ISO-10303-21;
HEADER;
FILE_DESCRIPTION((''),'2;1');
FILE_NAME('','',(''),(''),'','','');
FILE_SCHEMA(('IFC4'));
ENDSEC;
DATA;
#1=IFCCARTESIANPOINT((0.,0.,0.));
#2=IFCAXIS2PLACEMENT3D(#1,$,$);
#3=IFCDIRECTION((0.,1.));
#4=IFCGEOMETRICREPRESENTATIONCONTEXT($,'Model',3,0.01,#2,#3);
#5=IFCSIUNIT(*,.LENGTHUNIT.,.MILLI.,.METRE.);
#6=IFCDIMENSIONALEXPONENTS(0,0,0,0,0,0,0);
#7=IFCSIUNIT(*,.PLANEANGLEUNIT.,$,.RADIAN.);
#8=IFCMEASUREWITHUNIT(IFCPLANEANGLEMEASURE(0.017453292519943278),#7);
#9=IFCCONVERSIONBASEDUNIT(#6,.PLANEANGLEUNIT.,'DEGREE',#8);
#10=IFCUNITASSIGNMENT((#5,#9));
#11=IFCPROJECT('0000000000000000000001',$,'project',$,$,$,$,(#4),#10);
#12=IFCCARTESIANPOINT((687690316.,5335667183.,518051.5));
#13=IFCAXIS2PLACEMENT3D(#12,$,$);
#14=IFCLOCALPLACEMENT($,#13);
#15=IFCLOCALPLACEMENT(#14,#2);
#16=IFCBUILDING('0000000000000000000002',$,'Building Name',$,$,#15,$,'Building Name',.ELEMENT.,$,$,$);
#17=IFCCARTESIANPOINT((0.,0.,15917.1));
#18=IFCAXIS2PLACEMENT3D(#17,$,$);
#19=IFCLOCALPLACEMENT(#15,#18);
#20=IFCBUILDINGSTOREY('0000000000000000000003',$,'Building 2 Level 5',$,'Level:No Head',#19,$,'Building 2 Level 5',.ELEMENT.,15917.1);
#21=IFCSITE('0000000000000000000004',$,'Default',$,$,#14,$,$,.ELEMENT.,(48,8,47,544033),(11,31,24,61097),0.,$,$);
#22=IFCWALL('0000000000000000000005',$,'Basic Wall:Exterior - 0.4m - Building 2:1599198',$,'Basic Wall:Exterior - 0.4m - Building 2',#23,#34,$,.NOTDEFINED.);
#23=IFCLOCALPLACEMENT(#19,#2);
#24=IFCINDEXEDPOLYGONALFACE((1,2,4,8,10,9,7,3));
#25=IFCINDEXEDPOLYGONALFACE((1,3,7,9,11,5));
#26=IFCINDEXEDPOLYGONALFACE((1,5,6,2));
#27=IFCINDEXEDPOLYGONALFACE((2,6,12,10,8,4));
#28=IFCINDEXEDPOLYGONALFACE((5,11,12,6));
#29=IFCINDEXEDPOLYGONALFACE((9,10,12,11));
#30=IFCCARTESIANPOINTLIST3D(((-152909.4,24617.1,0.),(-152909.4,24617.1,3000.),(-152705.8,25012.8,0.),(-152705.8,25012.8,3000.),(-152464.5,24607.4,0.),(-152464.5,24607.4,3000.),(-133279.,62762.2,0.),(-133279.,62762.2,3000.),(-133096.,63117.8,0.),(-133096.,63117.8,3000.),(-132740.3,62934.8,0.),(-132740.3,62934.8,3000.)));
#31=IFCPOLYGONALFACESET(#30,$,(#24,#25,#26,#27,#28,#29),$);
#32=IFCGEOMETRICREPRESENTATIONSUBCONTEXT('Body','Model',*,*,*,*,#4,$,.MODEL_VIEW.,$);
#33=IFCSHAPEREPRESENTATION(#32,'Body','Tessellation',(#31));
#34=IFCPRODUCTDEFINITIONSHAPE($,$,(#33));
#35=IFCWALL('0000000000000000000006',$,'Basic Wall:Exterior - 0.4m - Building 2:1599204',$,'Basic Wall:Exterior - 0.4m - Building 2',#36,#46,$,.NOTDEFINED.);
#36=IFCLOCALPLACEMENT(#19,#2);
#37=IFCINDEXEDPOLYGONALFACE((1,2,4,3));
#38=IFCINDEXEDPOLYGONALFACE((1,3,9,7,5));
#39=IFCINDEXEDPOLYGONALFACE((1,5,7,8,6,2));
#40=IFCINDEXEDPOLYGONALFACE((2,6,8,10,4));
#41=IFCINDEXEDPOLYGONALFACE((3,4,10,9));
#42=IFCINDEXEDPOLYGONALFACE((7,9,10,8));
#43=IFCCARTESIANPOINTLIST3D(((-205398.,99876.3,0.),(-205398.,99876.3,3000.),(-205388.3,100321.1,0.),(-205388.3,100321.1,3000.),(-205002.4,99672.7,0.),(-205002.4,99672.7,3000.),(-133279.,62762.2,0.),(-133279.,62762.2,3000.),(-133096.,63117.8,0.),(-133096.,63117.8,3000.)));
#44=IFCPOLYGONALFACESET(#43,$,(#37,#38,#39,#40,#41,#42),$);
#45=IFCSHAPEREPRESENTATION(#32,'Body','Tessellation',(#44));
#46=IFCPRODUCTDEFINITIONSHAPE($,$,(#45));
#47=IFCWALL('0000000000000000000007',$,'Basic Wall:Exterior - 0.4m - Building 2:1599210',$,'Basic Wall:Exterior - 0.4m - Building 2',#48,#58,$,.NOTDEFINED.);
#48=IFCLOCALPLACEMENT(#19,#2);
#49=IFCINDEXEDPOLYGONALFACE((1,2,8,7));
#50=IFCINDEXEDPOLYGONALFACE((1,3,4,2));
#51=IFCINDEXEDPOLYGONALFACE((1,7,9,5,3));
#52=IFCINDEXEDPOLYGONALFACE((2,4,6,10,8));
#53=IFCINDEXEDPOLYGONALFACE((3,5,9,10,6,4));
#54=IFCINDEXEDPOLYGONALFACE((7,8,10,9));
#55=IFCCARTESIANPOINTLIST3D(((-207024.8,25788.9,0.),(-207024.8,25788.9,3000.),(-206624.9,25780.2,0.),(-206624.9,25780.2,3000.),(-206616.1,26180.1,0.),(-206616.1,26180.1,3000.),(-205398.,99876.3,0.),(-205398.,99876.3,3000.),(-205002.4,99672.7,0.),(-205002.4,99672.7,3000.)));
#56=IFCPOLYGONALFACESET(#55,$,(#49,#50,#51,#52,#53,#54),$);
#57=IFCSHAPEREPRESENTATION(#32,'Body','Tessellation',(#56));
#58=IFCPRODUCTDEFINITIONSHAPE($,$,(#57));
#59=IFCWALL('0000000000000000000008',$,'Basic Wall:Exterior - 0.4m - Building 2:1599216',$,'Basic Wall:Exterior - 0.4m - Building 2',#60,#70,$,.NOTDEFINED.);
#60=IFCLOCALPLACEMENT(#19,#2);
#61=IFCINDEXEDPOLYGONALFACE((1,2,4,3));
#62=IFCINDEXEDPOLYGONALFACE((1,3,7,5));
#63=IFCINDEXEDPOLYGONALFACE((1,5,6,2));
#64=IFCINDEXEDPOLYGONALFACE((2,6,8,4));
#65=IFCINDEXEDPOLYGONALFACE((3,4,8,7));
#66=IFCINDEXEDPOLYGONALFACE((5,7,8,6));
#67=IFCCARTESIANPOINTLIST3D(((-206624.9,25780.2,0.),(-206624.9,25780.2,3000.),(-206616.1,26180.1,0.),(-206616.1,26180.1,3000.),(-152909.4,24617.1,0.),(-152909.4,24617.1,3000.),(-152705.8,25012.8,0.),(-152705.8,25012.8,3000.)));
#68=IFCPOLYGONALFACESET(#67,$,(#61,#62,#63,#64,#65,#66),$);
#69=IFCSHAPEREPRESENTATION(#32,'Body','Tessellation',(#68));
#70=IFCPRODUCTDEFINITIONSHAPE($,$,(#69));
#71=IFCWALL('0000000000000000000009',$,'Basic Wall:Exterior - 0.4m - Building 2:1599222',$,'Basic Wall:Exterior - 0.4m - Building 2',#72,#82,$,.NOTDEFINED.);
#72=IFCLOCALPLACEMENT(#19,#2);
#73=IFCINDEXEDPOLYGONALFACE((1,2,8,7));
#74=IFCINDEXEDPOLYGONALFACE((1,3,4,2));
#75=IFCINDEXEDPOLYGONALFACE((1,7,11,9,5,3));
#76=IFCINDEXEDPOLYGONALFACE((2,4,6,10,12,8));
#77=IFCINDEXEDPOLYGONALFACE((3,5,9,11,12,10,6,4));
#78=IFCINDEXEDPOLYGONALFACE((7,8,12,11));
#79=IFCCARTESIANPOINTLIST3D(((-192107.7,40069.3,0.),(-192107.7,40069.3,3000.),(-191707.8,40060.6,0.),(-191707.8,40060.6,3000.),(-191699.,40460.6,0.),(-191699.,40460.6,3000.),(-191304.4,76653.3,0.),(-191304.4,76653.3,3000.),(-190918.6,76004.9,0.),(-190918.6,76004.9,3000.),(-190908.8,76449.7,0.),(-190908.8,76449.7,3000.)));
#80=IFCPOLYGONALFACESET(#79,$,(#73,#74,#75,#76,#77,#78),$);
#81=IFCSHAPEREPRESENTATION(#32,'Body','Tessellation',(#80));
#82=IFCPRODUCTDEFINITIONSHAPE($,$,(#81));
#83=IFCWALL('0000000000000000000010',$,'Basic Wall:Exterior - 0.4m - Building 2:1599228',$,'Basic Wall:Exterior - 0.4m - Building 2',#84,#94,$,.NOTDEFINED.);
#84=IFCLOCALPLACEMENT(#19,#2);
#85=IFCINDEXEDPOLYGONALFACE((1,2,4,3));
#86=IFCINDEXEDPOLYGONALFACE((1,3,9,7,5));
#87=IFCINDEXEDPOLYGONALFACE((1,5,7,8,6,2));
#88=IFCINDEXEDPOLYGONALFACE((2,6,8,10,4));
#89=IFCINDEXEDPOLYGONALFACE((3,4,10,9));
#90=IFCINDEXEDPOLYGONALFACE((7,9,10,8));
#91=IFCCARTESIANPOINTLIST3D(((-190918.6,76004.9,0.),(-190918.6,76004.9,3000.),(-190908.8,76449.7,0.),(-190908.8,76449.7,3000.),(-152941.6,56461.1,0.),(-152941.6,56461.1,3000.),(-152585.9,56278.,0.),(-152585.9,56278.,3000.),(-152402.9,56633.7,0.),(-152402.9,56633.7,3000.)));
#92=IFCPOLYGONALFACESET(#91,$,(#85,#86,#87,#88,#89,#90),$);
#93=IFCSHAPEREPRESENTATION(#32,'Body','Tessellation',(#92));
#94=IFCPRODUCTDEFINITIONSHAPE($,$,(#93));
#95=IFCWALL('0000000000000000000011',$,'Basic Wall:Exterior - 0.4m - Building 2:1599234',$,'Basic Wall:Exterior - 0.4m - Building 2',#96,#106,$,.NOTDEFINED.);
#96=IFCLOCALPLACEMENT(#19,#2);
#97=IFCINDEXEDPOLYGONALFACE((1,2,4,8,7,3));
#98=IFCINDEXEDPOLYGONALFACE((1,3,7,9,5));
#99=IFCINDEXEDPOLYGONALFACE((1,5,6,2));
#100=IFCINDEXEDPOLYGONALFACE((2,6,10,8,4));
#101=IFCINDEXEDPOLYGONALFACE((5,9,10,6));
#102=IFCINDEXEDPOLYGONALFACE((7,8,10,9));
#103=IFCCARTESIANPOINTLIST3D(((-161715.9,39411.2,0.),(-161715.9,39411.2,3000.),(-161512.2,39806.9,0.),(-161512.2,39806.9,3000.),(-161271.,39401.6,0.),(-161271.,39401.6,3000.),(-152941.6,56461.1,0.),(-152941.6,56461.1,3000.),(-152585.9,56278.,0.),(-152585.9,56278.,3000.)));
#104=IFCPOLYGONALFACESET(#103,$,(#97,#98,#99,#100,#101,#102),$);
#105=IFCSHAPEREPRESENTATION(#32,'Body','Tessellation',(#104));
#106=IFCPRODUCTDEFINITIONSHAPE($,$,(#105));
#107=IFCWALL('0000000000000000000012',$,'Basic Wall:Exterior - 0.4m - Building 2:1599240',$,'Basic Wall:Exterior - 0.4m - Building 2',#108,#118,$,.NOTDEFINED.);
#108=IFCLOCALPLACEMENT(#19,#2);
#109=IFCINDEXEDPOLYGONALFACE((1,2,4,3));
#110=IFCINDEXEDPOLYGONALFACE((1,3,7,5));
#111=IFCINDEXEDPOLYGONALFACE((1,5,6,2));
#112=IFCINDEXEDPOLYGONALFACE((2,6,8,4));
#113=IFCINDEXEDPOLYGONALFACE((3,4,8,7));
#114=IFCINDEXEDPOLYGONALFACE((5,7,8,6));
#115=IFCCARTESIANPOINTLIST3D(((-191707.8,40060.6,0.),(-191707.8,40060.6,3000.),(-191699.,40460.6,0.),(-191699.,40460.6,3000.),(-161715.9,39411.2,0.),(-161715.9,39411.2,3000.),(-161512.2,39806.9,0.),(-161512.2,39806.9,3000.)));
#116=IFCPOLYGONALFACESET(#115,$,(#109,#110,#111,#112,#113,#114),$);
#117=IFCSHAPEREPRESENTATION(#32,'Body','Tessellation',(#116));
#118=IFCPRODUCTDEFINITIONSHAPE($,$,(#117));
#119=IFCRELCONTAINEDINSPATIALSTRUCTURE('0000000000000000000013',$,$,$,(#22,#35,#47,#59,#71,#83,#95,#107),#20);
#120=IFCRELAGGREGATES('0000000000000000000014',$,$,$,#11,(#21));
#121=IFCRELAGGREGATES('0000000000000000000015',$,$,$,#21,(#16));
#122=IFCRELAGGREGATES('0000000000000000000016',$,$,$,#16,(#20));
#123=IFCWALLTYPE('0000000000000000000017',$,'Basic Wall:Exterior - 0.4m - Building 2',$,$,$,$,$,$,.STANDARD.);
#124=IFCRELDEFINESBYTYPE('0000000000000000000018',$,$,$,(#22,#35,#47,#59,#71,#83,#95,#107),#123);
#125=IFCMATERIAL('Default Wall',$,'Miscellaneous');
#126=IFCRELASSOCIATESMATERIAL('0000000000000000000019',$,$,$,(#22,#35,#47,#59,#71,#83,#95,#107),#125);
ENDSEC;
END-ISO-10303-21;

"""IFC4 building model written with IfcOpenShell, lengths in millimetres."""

from ifc_helpers import new_model, entity, si_unit, converted_unit, direction, frame, origin, place, context, subcontext, project, spatial, indexed_curve, outline, extrude, material, type_object, element, save


model = new_model("IFC4")

# Units and contexts
model_context = context("Model", 3, precision=0.01, world=origin(), true_north=direction((0.0, 1.0)))
body_context = subcontext(model_context, "Body", "Model", "MODEL_VIEW")
ifc_project = project(units=[si_unit("LENGTHUNIT", "METRE", prefix="MILLI"), converted_unit("PLANEANGLEUNIT", "DEGREE", entity("IfcPlaneAngleMeasure", 0.017453292519943278), si_unit("PLANEANGLEUNIT", "RADIAN"), dimensions=[0, 0, 0, 0, 0, 0, 0])], contexts=[model_context])

# Site, building, storey
site_placement = place(None, frame((687690316.0, 5335667183.0, 518051.5)))
site = spatial("IfcSite", under=ifc_project, at=site_placement, Name="Default", CompositionType="ELEMENT", RefLatitude=(48, 8, 47, 544033), RefLongitude=(11, 31, 24, 61097), RefElevation=0.0)
building_placement = place(site_placement, origin())
building = spatial("IfcBuilding", under=site, at=building_placement, Name="Building Name", LongName="Building Name", CompositionType="ELEMENT")
storey_placement = place(building_placement, frame((0.0, 0.0, 15917.1)))
storey = spatial("IfcBuildingStorey", under=building, at=storey_placement, Name="Building 2 Level 5", ObjectType="Level:No Head", LongName="Building 2 Level 5", CompositionType="ELEMENT", Elevation=15917.1)

# Walls
ifc_material_1 = material(Name="Default Wall", Category="Miscellaneous")
wall_type = type_object("IfcWallType", Name="Basic Wall:Exterior - 0.4m - Building 2", PredefinedType="STANDARD")
wall_1_placement = place(storey_placement, frame((-152731.6, 24525.6, 0.0), z_axis=(0.0, 0.0, 1.0), x_axis=(0.457585, 0.889166, 0.0)))
element("IfcWall", 1, at=wall_1_placement, inside=storey, type_object=wall_type, material=ifc_material_1, Name="Basic Wall:Exterior - 0.4m - Building 2:1599198", ObjectType="Basic Wall:Exterior - 0.4m - Building 2", PredefinedType="NOTDEFINED", context=body_context, shape_type="SweptSolid", body=[
    extrude(outline(indexed_curve([(43299.8, -200.0), (43299.8, 200.0), (42899.8, 200.0), (445.0, 200.0), (0.0, 200.0), (195.0, -200.0), (43299.8, -200.0)], self_intersect=False)), origin(), (0.0, 0.0, 1.0), 3000.0),
])
wall_2_placement = place(storey_placement, frame((-133187.5, 62940.0, 0.0), z_axis=(0.0, 0.0, 1.0), x_axis=(-0.889166, 0.457585, 0.0)))
element("IfcWall", 2, at=wall_2_placement, inside=storey, type_object=wall_type, material=ifc_material_1, Name="Basic Wall:Exterior - 0.4m - Building 2:1599204", ObjectType="Basic Wall:Exterior - 0.4m - Building 2", PredefinedType="NOTDEFINED", context=body_context, shape_type="SweptSolid", body=[
    extrude(outline(indexed_curve([(81303.5, -200.0), (81108.6, 200.0), (80663.7, 200.0), (0.0, 200.0), (0.0, -200.0), (81303.5, -200.0)], self_intersect=False)), origin(), (0.0, 0.0, 1.0), 3000.0),
])
wall_3_placement = place(storey_placement, frame((-205198.1, 99871.9, 0.0), z_axis=(0.0, 0.0, 1.0), x_axis=(-0.021952, -0.999759, 0.0)))
element("IfcWall", 3, at=wall_3_placement, inside=storey, type_object=wall_type, material=ifc_material_1, Name="Basic Wall:Exterior - 0.4m - Building 2:1599210", ObjectType="Basic Wall:Exterior - 0.4m - Building 2", PredefinedType="NOTDEFINED", context=body_context, shape_type="SweptSolid", body=[
    extrude(outline(indexed_curve([(74105.2, -200.0), (74105.1, 200.0), (73705.1, 200.0), (194.9, 200.0), (0.0, -200.0), (74105.2, -200.0)], self_intersect=False)), origin(), (0.0, 0.0, 1.0), 3000.0),
])
wall_4_placement = place(storey_placement, frame((-206620.6, 25980.2, 0.0), z_axis=(0.0, 0.0, 1.0), x_axis=(0.999766, -0.021649, 0.0)))
element("IfcWall", 4, at=wall_4_placement, inside=storey, type_object=wall_type, material=ifc_material_1, Name="Basic Wall:Exterior - 0.4m - Building 2:1599216", ObjectType="Basic Wall:Exterior - 0.4m - Building 2", PredefinedType="NOTDEFINED", context=body_context, shape_type="SweptSolid", body=[
    extrude(outline(indexed_curve([(53728.1, -200.0), (53923.1, 200.0), (0.1, 200.0), (0.0, -200.0), (53728.1, -200.0)], self_intersect=False)), origin(), (0.0, 0.0, 1.0), 3000.0),
])
wall_5_placement = place(storey_placement, frame((-191907.8, 40064.9, 0.0), z_axis=(0.0, 0.0, 1.0), x_axis=(0.021952, 0.999759, 0.0)))
element("IfcWall", 5, at=wall_5_placement, inside=storey, type_object=wall_type, material=ifc_material_1, Name="Basic Wall:Exterior - 0.4m - Building 2:1599222", ObjectType="Basic Wall:Exterior - 0.4m - Building 2", PredefinedType="NOTDEFINED", context=body_context, shape_type="SweptSolid", body=[
    extrude(outline(indexed_curve([(36398.0, -200.0), (36592.9, 200.0), (0.0, 200.0), (0.1, -200.0), (400.1, -200.0), (35953.1, -200.0), (36398.0, -200.0)], self_intersect=False)), origin(), (0.0, 0.0, 1.0), 3000.0),
])
wall_6_placement = place(storey_placement, frame((-191000.3, 76271.9, 0.0), z_axis=(0.0, 0.0, 1.0), x_axis=(0.889166, -0.457585, 0.0)))
element("IfcWall", 6, at=wall_6_placement, inside=storey, type_object=wall_type, material=ifc_material_1, Name="Basic Wall:Exterior - 0.4m - Building 2:1599228", ObjectType="Basic Wall:Exterior - 0.4m - Building 2", PredefinedType="NOTDEFINED", context=body_context, shape_type="SweptSolid", body=[
    extrude(outline(indexed_curve([(43305.7, -200.0), (43305.7, 200.0), (0.0, 200.0), (194.9, -200.0), (42905.7, -200.0), (43305.7, -200.0)], self_intersect=False)), origin(), (0.0, 0.0, 1.0), 3000.0),
])
wall_7_placement = place(storey_placement, frame((-152763.8, 56369.6, 0.0), z_axis=(0.0, 0.0, 1.0), x_axis=(-0.457585, -0.889166, 0.0)))
element("IfcWall", 7, at=wall_7_placement, inside=storey, type_object=wall_type, material=ifc_material_1, Name="Basic Wall:Exterior - 0.4m - Building 2:1599234", ObjectType="Basic Wall:Exterior - 0.4m - Building 2", PredefinedType="NOTDEFINED", context=body_context, shape_type="SweptSolid", body=[
    extrude(outline(indexed_curve([(19175.1, -200.0), (18980.1, 200.0), (0.0, 200.0), (0.0, -200.0), (18730.1, -200.0), (19175.1, -200.0)], self_intersect=False)), origin(), (0.0, 0.0, 1.0), 3000.0),
])
wall_8_placement = place(storey_placement, frame((-161516.6, 39606.9, 0.0), z_axis=(0.0, 0.0, 1.0), x_axis=(-0.999766, 0.021649, 0.0)))
element("IfcWall", 8, at=wall_8_placement, inside=storey, type_object=wall_type, material=ifc_material_1, Name="Basic Wall:Exterior - 0.4m - Building 2:1599240", ObjectType="Basic Wall:Exterior - 0.4m - Building 2", PredefinedType="NOTDEFINED", context=body_context, shape_type="SweptSolid", body=[
    extrude(outline(indexed_curve([(30193.9, -200.0), (30194.0, 200.0), (195.0, 200.0), (0.0, -200.0), (30193.9, -200.0)], self_intersect=False)), origin(), (0.0, 0.0, 1.0), 3000.0),
])

save(model, "model.ifc")
